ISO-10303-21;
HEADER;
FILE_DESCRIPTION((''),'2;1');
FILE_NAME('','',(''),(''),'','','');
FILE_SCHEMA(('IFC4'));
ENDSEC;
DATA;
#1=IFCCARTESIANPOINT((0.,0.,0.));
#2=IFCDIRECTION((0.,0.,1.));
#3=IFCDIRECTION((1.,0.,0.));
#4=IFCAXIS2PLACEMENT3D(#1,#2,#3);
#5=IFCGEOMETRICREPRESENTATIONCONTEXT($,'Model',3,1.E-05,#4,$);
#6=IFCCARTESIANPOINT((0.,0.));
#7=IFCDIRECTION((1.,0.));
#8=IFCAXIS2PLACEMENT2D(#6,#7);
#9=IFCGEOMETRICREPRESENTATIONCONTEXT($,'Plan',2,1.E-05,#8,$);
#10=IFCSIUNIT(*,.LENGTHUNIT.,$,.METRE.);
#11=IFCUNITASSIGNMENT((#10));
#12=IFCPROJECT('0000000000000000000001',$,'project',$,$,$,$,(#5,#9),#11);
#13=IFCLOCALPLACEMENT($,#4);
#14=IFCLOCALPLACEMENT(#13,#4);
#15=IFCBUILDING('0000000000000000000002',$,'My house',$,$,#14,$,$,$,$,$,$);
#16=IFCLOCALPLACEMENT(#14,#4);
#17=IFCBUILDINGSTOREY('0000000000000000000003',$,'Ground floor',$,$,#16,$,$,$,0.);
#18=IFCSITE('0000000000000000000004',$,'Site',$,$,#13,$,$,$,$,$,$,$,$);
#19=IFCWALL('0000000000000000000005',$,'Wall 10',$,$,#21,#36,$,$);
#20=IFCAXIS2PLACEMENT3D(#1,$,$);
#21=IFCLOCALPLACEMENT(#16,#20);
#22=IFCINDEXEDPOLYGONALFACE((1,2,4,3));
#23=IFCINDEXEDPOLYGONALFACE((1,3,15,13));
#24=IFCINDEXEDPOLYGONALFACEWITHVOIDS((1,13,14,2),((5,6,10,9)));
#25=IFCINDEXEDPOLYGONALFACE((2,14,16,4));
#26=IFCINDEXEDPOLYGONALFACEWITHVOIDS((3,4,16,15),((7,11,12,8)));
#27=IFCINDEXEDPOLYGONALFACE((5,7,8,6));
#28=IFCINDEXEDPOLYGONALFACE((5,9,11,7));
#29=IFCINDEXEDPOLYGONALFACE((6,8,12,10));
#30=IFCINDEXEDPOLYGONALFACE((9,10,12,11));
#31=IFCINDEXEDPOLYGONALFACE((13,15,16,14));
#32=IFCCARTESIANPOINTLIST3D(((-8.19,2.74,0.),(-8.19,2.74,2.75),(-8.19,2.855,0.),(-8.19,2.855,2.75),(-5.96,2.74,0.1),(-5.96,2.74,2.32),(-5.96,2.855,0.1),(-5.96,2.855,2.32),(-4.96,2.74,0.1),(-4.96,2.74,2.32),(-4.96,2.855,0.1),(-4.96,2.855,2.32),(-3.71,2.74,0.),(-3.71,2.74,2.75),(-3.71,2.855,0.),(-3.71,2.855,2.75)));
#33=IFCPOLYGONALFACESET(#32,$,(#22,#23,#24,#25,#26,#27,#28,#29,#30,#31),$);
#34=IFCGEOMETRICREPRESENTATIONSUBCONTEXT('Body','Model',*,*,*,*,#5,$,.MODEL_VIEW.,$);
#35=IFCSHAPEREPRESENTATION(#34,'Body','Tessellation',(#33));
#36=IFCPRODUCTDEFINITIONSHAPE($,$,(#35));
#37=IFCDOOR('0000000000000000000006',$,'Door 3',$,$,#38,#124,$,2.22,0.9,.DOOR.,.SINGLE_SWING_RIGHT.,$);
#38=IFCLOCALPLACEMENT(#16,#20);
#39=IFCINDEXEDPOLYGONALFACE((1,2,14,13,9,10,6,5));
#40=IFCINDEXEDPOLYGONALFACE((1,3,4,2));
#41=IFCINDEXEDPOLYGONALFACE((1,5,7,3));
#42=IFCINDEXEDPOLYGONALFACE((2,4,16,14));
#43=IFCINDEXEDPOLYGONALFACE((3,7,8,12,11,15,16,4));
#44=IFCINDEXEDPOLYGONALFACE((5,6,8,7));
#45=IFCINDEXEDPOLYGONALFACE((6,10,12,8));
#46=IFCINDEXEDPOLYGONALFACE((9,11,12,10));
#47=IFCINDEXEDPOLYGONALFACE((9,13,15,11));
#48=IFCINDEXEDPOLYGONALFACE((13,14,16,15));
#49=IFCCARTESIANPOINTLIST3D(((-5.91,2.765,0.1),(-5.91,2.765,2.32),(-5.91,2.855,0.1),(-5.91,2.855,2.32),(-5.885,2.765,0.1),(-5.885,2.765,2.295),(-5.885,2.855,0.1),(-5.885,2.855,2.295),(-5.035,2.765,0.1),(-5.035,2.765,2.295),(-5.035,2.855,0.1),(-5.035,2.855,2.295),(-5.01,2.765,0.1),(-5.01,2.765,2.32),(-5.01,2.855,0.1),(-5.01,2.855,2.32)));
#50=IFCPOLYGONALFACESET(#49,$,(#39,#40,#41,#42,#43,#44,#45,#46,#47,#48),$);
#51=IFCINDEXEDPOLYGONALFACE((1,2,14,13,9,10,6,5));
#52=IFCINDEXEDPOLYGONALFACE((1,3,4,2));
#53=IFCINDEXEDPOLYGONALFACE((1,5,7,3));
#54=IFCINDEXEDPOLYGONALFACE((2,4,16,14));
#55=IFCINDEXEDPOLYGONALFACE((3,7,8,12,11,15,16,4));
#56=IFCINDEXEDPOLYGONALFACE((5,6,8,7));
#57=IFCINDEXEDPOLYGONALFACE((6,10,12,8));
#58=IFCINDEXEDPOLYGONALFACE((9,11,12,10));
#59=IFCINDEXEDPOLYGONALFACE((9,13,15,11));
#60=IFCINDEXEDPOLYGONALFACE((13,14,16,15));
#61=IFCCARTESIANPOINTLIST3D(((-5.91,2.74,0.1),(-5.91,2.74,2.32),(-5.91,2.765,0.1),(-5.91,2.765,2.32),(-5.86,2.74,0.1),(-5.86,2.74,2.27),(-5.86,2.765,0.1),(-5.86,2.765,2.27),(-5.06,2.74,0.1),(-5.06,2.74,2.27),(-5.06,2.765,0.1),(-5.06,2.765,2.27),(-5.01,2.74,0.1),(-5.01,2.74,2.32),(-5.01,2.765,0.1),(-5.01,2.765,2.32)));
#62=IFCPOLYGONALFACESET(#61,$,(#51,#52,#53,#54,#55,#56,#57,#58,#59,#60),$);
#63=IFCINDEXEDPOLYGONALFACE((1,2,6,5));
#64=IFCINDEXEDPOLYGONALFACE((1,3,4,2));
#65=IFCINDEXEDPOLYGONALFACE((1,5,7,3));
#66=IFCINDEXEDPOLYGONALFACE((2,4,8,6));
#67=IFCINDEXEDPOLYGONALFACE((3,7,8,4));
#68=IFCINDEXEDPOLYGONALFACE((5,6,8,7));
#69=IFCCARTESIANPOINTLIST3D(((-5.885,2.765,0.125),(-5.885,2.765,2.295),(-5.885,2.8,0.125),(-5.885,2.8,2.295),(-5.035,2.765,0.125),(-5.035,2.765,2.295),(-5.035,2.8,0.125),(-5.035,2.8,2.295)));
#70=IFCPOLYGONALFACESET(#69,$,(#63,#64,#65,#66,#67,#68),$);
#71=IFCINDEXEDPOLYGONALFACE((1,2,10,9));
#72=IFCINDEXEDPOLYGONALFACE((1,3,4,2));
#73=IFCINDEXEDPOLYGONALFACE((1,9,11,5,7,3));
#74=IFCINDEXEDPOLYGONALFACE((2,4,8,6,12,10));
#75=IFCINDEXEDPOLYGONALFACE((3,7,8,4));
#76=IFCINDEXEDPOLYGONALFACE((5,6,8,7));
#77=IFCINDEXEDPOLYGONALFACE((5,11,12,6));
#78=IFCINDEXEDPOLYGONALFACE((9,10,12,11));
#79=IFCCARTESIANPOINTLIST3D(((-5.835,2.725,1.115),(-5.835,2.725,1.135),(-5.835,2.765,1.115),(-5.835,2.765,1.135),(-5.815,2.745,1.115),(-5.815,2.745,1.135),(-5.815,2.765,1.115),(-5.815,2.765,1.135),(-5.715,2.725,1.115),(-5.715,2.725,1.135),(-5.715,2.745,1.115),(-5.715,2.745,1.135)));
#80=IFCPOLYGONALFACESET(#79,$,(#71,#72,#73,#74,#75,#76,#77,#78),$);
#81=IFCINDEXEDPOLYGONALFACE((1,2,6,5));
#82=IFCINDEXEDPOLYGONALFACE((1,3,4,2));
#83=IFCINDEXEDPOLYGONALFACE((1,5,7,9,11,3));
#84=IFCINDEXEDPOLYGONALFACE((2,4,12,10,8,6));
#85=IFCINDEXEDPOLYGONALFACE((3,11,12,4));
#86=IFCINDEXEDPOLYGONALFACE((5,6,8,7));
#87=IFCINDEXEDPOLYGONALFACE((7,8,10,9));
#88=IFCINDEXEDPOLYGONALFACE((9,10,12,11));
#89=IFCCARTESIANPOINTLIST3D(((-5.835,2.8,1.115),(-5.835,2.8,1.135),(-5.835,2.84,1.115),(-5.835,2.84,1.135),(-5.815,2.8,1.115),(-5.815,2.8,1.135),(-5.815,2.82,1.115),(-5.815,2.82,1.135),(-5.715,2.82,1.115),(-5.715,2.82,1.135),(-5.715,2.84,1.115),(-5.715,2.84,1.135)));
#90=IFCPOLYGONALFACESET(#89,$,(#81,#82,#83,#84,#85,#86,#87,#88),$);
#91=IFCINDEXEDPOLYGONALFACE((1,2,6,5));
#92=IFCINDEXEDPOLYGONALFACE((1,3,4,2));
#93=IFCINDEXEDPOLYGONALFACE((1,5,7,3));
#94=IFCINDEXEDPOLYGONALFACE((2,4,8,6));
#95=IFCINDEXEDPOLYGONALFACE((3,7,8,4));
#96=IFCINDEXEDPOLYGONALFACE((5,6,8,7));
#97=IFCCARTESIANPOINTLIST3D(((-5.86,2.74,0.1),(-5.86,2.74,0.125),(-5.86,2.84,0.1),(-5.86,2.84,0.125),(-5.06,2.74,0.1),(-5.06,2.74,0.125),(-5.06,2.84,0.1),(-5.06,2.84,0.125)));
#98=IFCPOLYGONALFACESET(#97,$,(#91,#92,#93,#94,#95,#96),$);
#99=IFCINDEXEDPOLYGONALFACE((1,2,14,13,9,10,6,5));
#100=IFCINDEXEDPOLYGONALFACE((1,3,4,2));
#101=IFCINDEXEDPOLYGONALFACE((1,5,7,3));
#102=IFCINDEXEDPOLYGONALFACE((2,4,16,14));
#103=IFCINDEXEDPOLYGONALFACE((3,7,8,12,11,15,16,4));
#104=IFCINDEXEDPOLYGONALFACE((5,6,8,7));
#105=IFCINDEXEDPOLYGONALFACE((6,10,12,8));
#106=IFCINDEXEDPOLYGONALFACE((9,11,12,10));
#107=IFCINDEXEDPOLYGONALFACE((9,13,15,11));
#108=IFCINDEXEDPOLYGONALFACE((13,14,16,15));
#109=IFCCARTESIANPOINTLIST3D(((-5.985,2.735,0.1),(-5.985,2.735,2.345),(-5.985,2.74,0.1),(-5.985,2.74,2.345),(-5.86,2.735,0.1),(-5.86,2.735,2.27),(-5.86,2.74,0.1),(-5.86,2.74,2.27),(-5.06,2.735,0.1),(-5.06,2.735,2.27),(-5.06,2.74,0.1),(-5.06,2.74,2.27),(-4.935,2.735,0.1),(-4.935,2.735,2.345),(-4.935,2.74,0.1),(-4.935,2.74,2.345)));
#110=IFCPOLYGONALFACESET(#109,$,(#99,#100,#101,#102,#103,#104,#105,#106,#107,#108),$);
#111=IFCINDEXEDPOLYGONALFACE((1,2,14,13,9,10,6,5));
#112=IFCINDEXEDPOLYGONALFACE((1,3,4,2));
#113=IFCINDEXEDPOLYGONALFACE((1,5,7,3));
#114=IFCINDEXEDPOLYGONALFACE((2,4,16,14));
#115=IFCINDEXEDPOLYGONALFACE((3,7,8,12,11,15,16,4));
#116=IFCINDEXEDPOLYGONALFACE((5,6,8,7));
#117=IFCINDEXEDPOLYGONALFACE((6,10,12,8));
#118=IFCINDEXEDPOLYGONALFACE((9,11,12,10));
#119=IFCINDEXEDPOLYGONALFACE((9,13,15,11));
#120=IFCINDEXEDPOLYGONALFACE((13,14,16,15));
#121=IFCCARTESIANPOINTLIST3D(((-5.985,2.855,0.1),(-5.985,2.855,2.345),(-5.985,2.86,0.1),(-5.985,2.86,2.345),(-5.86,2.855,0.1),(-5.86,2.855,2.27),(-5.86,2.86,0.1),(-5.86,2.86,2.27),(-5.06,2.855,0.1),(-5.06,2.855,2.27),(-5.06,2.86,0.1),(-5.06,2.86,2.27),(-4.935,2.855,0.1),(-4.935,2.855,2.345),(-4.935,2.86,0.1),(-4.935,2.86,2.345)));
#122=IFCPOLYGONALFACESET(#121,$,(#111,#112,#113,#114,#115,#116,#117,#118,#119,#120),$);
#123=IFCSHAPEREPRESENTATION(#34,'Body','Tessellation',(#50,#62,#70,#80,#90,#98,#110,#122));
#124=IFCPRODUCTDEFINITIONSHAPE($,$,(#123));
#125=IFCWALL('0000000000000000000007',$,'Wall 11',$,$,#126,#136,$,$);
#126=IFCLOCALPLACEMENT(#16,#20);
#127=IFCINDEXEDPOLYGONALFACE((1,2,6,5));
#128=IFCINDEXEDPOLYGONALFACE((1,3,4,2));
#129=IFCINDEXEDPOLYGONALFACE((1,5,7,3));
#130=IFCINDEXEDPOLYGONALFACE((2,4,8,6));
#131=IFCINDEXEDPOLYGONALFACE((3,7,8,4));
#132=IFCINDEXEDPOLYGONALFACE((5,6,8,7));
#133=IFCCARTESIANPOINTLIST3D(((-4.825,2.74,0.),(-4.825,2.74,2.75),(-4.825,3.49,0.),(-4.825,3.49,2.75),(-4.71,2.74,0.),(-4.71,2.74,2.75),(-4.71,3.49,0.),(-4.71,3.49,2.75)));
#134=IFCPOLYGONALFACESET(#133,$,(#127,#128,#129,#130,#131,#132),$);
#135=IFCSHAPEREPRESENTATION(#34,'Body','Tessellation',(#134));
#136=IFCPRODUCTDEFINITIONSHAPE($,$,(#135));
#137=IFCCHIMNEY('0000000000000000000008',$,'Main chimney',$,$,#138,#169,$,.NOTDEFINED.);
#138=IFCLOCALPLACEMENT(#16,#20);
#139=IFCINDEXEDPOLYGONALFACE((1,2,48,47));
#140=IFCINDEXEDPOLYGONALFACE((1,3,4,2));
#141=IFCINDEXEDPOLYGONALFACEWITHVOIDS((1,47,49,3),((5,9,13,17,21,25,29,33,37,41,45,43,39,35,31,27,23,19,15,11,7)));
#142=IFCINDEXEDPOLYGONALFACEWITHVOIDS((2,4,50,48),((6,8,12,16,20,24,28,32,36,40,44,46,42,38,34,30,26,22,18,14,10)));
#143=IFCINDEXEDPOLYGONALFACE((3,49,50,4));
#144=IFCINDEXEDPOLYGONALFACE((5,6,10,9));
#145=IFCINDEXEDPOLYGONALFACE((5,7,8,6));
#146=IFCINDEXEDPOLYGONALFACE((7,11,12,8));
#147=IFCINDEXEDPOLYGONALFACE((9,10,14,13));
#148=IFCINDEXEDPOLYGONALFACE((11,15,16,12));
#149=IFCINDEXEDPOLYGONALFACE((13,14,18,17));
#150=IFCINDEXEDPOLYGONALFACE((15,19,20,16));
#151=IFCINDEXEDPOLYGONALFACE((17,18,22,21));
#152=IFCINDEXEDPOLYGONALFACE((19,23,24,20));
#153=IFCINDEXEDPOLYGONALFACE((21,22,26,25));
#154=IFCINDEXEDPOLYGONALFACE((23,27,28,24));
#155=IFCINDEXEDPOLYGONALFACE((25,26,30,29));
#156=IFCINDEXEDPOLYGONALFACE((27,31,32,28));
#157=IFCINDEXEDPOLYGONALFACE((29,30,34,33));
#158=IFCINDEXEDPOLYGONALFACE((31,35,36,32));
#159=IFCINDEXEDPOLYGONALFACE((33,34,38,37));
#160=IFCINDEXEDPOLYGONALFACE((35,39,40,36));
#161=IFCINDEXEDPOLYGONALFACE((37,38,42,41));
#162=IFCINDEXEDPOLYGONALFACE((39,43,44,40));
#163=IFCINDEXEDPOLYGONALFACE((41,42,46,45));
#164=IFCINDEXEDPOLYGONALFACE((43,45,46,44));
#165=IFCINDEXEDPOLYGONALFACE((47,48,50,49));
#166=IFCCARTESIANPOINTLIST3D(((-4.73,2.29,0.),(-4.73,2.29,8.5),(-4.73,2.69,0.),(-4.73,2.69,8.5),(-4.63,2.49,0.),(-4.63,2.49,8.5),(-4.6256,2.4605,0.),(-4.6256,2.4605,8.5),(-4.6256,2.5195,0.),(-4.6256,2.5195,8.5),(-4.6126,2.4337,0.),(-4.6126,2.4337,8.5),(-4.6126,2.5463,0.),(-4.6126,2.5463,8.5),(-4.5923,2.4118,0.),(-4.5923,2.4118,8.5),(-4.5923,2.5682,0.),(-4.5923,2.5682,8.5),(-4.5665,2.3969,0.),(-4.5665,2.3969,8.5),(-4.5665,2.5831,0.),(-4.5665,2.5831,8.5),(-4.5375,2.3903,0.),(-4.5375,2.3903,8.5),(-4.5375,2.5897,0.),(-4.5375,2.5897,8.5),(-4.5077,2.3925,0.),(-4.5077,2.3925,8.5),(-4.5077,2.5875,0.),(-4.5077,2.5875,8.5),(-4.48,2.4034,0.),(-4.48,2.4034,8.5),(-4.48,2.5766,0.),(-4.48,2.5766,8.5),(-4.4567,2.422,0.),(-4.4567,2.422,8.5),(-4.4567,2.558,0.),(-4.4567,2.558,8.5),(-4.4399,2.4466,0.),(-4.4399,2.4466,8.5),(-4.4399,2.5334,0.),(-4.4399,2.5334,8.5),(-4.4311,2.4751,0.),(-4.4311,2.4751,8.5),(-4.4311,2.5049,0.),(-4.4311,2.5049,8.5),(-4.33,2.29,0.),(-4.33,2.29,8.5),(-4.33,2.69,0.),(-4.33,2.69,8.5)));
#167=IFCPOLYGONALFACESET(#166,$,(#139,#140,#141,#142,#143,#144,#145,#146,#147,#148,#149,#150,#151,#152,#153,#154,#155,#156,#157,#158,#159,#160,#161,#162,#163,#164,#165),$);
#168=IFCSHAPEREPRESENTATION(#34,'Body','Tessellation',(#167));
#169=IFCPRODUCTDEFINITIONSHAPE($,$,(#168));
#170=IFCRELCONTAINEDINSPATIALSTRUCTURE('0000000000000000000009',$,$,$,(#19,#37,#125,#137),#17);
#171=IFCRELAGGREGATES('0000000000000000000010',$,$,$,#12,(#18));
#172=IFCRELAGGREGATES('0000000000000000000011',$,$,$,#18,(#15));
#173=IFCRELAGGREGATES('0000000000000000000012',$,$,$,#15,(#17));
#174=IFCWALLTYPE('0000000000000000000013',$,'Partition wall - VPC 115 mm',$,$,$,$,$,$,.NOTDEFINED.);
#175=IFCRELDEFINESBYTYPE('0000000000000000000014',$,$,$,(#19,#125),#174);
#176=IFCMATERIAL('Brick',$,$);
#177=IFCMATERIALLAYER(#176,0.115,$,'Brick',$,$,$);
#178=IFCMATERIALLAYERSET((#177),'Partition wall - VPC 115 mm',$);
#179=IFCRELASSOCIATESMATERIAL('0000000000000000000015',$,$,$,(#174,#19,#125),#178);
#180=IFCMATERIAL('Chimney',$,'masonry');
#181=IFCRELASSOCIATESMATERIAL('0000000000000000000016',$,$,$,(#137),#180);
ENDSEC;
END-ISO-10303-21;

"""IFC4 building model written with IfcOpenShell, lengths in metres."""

from ifc_helpers import new_model, entity, si_unit, frame, origin_with_axes, origin_2d_with_axis, place, context, subcontext, project, spatial, line, indexed_curve, circle_curve, outline, extrude, shape, source, transform, mapped, material, layer, layer_set, layer_usage, type_object, element, fill, save


model = new_model("IFC4")

# Units and contexts
model_context = context("Model", 3, precision=1e-05, world=origin_with_axes())
plan_context = context("Plan", 2, precision=1e-05, world=origin_2d_with_axis())
body_context_1 = subcontext(model_context, "Body", "Model", "MODEL_VIEW")
body_context_2 = subcontext(plan_context, "Body", "Plan", "PLAN_VIEW")
ifc_project = project(units=[si_unit("LENGTHUNIT", "METRE")], contexts=[model_context, plan_context])

# Site, building, storey
site_placement = place(None, origin_with_axes())
site = spatial("IfcSite", under=ifc_project, at=site_placement, Name="Site")
building_placement = place(site_placement, origin_with_axes())
building = spatial("IfcBuilding", under=site, at=building_placement, Name="My house")
storey_placement = place(building_placement, origin_with_axes())
storey = spatial("IfcBuildingStorey", under=building, at=storey_placement, Name="Ground floor", Elevation=0.0)

# Shared definitions
ifc_material_1 = material(Name="Brick")

# Wall, opening, door
ifc_layer_1 = layer(ifc_material_1, 0.115, Name="Brick")
ifc_layer_set_1 = layer_set([ifc_layer_1], Name="Partition wall - VPC 115 mm")
ifc_layer_usage_1 = layer_usage(ifc_layer_set_1, "AXIS2", "NEGATIVE", 0.115)
wall_type_1 = type_object("IfcWallType", Name="Partition wall - VPC 115 mm", PredefinedType="NOTDEFINED", material=ifc_layer_set_1)
shared_shape_1 = source(origin_with_axes(), body_context_1, "Body", "SweptSolid", [
    extrude(outline(indexed_curve([(0.0, 0.0), (0.0, 0.115), (4.48, 0.115), (4.48, 0.0), (0.0, 0.0)], self_intersect=False)), origin_with_axes(), (0.0, 0.0, 1.0), 2.75),
])
wall_1_placement = place(storey_placement, frame((-3.71, 2.74, 0.0), z_axis=(0.0, 0.0, 1.0), x_axis=(1.0, 0.0, 0.0)))
wall_1 = element("IfcWall", 1, at=wall_1_placement, inside=storey, type_object=wall_type_1, material=ifc_layer_usage_1, Name="Wall 10", context=body_context_1, shape_type="MappedRepresentation", body=[
    mapped(shared_shape_1, transform((0.0, 0.0, 0.0), x_axis=(-1.0, 0.0, 0.0), y_axis=(0.0, 1.0, 0.0), z_axis=(0.0, 0.0, 1.0), scale=1.0)),
])
shared_shape_2 = source(origin_with_axes(), body_context_1, "Body", "SweptSolid", [
    extrude(outline(indexed_curve([(0.0, 0.0), (0.0, 0.215), (1.0, 0.215), (1.0, 0.0), (0.0, 0.0)], self_intersect=False)), frame((0.0, -0.05, 0.0), z_axis=(0.0, 0.0, 1.0), x_axis=(1.0, 0.0, 0.0)), (0.0, 0.0, 1.0), 2.22),
])
opening_1_placement = place(wall_1_placement, frame((-1.25, 0.0, 0.1), z_axis=(0.0, 0.0, 1.0), x_axis=(1.0, 0.0, 0.0)))
opening_1 = element("IfcOpeningElement", 2, at=opening_1_placement, cuts=wall_1, PredefinedType="OPENING", context=body_context_1, shape_type="MappedRepresentation", body=[
    mapped(shared_shape_2, transform((0.0, 0.0, 0.0), x_axis=(-1.0, 0.0, 0.0), y_axis=(0.0, 1.0, 0.0), z_axis=(0.0, 0.0, 1.0), scale=1.0)),
])
shared_indexed_poly_curve_1 = entity("IfcIndexedPolyCurve", entity("IfcCartesianPointList2D", [[-0.075, 0.0], [-0.075, 2.245], [0.975, 2.245], [0.975, 0.0], [0.85, 0.0], [0.85, 2.17], [0.05, 2.17], [0.05, 0.0]]), [entity("IfcLineIndex", [1, 2, 3, 4, 5, 6, 7, 8, 1])])
shared_shape_3 = source(origin_with_axes(), body_context_1, "Body", "SweptSolid", [
    extrude(outline(indexed_curve([(0.0, 0.0), (0.0, 2.22), (0.9, 2.22), (0.9, 0.0), (0.875, 0.0), (0.875, 2.195), (0.025, 2.195), (0.025, 0.0)], segments=[line(1, 2, 3, 4, 5, 6, 7, 8, 1)])), frame((0.0, 0.025, 0.0), z_axis=(0.0, -1.0, 0.0), x_axis=(1.0, 0.0, 0.0)), (0.0, 0.0, -1.0), 0.09),
    extrude(outline(indexed_curve([(0.0, 0.0), (0.0, 2.22), (0.9, 2.22), (0.9, 0.0), (0.85, 0.0), (0.85, 2.17), (0.05, 2.17), (0.05, 0.0)], segments=[line(1, 2, 3, 4, 5, 6, 7, 8, 1)])), frame((0.0, 0.0, 0.0), z_axis=(0.0, -1.0, 0.0), x_axis=(1.0, 0.0, 0.0)), (0.0, 0.0, -1.0), 0.025),
    extrude(outline(indexed_curve([(0.0, 0.0), (0.85, 0.0), (0.85, 0.035), (0.0, 0.035)], segments=[line(1, 2, 3, 4, 1)])), frame((0.025, 0.025, 0.025), z_axis=(0.0, 0.0, 1.0), x_axis=(1.0, 0.0, 0.0)), (0.0, 0.0, 1.0), 2.17),
    extrude(outline(indexed_curve([(0.0, 0.0), (0.0, -0.04), (-0.12, -0.04), (-0.12, -0.02), (-0.02, -0.02), (-0.02, 0.0)], segments=[line(1, 2, 3, 4, 5, 6, 1)])), frame((0.825, 0.025, 1.015), z_axis=(0.0, 0.0, 1.0), x_axis=(1.0, 0.0, 0.0)), (0.0, 0.0, 1.0), 0.02),
    extrude(outline(indexed_curve([(0.0, 0.0), (0.0, 0.04), (-0.12, 0.04), (-0.12, 0.02), (-0.02, 0.02), (-0.02, 0.0)], segments=[line(1, 2, 3, 4, 5, 6, 1)])), frame((0.825, 0.06, 1.015), z_axis=(0.0, 0.0, 1.0), x_axis=(1.0, 0.0, 0.0)), (0.0, 0.0, 1.0), 0.02),
    extrude(outline(indexed_curve([(0.0, 0.0), (0.8, 0.0), (0.8, 0.1), (0.0, 0.1)], segments=[line(1, 2, 3, 4, 1)])), frame((0.05, 0.0, 0.0), z_axis=(0.0, 0.0, 1.0), x_axis=(1.0, 0.0, 0.0)), (0.0, 0.0, 1.0), 0.025),
    entity("IfcExtrudedAreaSolid", entity("IfcArbitraryClosedProfileDef", "AREA", None, shared_indexed_poly_curve_1), entity("IfcAxis2Placement3D", entity("IfcCartesianPoint", [0.0, -0.005, 0.0]), entity("IfcDirection", [0.0, -1.0, 0.0]), entity("IfcDirection", [1.0, 0.0, 0.0])), entity("IfcDirection", [0.0, 0.0, -1.0]), 0.005),
    entity("IfcExtrudedAreaSolid", entity("IfcArbitraryClosedProfileDef", "AREA", None, shared_indexed_poly_curve_1), entity("IfcAxis2Placement3D", entity("IfcCartesianPoint", [0.0, 0.115, 0.0]), entity("IfcDirection", [0.0, -1.0, 0.0]), entity("IfcDirection", [1.0, 0.0, 0.0])), entity("IfcDirection", [0.0, 0.0, -1.0]), 0.005),
])
shared_shape_4 = source(origin_with_axes(), body_context_2, "Body", "Curve2D", [
    entity("IfcIndexedPolyCurve", entity("IfcCartesianPointList2D", [[0.0, 0.0], [0.0, 0.115], [0.025, 0.115], [0.025, 0.025], [0.05, 0.025], [0.05, 0.0]]), [entity("IfcLineIndex", [1, 2, 3, 4, 5, 6, 1])]),
    entity("IfcIndexedPolyCurve", entity("IfcCartesianPointList2D", [[0.9, 0.0], [0.9, 0.115], [0.875, 0.115], [0.875, 0.025], [0.85, 0.025], [0.85, 0.0]]), [entity("IfcLineIndex", [1, 2, 3, 4, 5, 6, 1])]),
    entity("IfcTrimmedCurve", entity("IfcEllipse", entity("IfcAxis2Placement2D", entity("IfcCartesianPoint", [0.06, 0.115]), entity("IfcDirection", [1.0, 0.0])), 0.815, 0.85), [entity("IfcCartesianPoint", [0.875, 0.115])], [entity("IfcCartesianPoint", [0.06, 0.965])], True, "CARTESIAN"),
    entity("IfcIndexedPolyCurve", entity("IfcCartesianPointList2D", [[0.025, 0.115], [0.06, 0.115], [0.06, 0.965], [0.025, 0.965]]), [entity("IfcLineIndex", [1, 2, 3, 4, 1])]),
])
door_1_placement = place(opening_1_placement, frame((-0.05, 0.0, 0.0), z_axis=(0.0, 0.0, 1.0), x_axis=(1.0, 0.0, 0.0)))
door_1 = element("IfcDoor", 3, at=door_1_placement, inside=storey, Name="Door 3", OperationType="SINGLE_SWING_RIGHT", OverallHeight=2.22, OverallWidth=0.9, PredefinedType="DOOR", shapes=[
    shape(body_context_1, "Body", "MappedRepresentation", [mapped(shared_shape_3, transform((0.0, 0.0, 0.0), x_axis=(-1.0, 0.0, 0.0), y_axis=(0.0, 1.0, 0.0), z_axis=(0.0, 0.0, 1.0), scale=1.0))]),
    shape(body_context_2, "Body", "MappedRepresentation", [mapped(shared_shape_4, transform((0.0, 0.0, 0.0), x_axis=(-1.0, 0.0, 0.0), y_axis=(0.0, 1.0, 0.0), z_axis=(0.0, 0.0, 1.0), scale=1.0))]),
])
fill(opening_1, door_1)

# Wall
ifc_layer_usage_2 = layer_usage(ifc_layer_set_1, "AXIS2", "NEGATIVE", 0.115)
shared_shape_5 = source(origin_with_axes(), body_context_1, "Body", "SweptSolid", [
    extrude(outline(indexed_curve([(0.0, 0.0), (0.0, 0.115), (0.75, 0.115), (0.75, 0.0), (0.0, 0.0)], self_intersect=False)), origin_with_axes(), (0.0, 0.0, 1.0), 2.75),
])
wall_2_placement = place(storey_placement, frame((-4.71, 3.49, 0.0), z_axis=(0.0, 0.0, 1.0), x_axis=(0.0, 1.0, 0.0)))
element("IfcWall", 4, at=wall_2_placement, inside=storey, type_object=wall_type_1, material=ifc_layer_usage_2, Name="Wall 11", context=body_context_1, shape_type="MappedRepresentation", body=[
    mapped(shared_shape_5, transform((0.0, 0.0, 0.0), x_axis=(-1.0, 0.0, 0.0), y_axis=(0.0, 1.0, 0.0), z_axis=(0.0, 0.0, 1.0), scale=1.0)),
])

# Chimney
ifc_material_2 = material(Name="Chimney", Category="masonry")
shared_shape_6 = source(origin_with_axes(), body_context_1, "Body", "SweptSolid", [
    extrude(outline(indexed_curve([(-0.2, -0.2), (0.2, -0.2), (0.2, 0.2), (-0.2, 0.2), (-0.2, -0.2)], self_intersect=False), holes=[circle_curve(origin_2d_with_axis(), 0.1)]), origin_with_axes(), (0.0, 0.0, 1.0), 8.5),
])
chimney_placement = place(storey_placement, frame((-4.53, 2.49, 0.0), z_axis=(0.0, 0.0, 1.0), x_axis=(1.0, 0.0, 0.0)))
element("IfcChimney", 5, at=chimney_placement, inside=storey, material=ifc_material_2, Name="Main chimney", PredefinedType="NOTDEFINED", context=body_context_1, shape_type="MappedRepresentation", body=[
    mapped(shared_shape_6, transform((0.0, 0.0, 0.0), x_axis=(-1.0, 0.0, 0.0), y_axis=(0.0, 1.0, 0.0), z_axis=(0.0, 0.0, 1.0), scale=1.0)),
])

save(model, "model.ifc")
